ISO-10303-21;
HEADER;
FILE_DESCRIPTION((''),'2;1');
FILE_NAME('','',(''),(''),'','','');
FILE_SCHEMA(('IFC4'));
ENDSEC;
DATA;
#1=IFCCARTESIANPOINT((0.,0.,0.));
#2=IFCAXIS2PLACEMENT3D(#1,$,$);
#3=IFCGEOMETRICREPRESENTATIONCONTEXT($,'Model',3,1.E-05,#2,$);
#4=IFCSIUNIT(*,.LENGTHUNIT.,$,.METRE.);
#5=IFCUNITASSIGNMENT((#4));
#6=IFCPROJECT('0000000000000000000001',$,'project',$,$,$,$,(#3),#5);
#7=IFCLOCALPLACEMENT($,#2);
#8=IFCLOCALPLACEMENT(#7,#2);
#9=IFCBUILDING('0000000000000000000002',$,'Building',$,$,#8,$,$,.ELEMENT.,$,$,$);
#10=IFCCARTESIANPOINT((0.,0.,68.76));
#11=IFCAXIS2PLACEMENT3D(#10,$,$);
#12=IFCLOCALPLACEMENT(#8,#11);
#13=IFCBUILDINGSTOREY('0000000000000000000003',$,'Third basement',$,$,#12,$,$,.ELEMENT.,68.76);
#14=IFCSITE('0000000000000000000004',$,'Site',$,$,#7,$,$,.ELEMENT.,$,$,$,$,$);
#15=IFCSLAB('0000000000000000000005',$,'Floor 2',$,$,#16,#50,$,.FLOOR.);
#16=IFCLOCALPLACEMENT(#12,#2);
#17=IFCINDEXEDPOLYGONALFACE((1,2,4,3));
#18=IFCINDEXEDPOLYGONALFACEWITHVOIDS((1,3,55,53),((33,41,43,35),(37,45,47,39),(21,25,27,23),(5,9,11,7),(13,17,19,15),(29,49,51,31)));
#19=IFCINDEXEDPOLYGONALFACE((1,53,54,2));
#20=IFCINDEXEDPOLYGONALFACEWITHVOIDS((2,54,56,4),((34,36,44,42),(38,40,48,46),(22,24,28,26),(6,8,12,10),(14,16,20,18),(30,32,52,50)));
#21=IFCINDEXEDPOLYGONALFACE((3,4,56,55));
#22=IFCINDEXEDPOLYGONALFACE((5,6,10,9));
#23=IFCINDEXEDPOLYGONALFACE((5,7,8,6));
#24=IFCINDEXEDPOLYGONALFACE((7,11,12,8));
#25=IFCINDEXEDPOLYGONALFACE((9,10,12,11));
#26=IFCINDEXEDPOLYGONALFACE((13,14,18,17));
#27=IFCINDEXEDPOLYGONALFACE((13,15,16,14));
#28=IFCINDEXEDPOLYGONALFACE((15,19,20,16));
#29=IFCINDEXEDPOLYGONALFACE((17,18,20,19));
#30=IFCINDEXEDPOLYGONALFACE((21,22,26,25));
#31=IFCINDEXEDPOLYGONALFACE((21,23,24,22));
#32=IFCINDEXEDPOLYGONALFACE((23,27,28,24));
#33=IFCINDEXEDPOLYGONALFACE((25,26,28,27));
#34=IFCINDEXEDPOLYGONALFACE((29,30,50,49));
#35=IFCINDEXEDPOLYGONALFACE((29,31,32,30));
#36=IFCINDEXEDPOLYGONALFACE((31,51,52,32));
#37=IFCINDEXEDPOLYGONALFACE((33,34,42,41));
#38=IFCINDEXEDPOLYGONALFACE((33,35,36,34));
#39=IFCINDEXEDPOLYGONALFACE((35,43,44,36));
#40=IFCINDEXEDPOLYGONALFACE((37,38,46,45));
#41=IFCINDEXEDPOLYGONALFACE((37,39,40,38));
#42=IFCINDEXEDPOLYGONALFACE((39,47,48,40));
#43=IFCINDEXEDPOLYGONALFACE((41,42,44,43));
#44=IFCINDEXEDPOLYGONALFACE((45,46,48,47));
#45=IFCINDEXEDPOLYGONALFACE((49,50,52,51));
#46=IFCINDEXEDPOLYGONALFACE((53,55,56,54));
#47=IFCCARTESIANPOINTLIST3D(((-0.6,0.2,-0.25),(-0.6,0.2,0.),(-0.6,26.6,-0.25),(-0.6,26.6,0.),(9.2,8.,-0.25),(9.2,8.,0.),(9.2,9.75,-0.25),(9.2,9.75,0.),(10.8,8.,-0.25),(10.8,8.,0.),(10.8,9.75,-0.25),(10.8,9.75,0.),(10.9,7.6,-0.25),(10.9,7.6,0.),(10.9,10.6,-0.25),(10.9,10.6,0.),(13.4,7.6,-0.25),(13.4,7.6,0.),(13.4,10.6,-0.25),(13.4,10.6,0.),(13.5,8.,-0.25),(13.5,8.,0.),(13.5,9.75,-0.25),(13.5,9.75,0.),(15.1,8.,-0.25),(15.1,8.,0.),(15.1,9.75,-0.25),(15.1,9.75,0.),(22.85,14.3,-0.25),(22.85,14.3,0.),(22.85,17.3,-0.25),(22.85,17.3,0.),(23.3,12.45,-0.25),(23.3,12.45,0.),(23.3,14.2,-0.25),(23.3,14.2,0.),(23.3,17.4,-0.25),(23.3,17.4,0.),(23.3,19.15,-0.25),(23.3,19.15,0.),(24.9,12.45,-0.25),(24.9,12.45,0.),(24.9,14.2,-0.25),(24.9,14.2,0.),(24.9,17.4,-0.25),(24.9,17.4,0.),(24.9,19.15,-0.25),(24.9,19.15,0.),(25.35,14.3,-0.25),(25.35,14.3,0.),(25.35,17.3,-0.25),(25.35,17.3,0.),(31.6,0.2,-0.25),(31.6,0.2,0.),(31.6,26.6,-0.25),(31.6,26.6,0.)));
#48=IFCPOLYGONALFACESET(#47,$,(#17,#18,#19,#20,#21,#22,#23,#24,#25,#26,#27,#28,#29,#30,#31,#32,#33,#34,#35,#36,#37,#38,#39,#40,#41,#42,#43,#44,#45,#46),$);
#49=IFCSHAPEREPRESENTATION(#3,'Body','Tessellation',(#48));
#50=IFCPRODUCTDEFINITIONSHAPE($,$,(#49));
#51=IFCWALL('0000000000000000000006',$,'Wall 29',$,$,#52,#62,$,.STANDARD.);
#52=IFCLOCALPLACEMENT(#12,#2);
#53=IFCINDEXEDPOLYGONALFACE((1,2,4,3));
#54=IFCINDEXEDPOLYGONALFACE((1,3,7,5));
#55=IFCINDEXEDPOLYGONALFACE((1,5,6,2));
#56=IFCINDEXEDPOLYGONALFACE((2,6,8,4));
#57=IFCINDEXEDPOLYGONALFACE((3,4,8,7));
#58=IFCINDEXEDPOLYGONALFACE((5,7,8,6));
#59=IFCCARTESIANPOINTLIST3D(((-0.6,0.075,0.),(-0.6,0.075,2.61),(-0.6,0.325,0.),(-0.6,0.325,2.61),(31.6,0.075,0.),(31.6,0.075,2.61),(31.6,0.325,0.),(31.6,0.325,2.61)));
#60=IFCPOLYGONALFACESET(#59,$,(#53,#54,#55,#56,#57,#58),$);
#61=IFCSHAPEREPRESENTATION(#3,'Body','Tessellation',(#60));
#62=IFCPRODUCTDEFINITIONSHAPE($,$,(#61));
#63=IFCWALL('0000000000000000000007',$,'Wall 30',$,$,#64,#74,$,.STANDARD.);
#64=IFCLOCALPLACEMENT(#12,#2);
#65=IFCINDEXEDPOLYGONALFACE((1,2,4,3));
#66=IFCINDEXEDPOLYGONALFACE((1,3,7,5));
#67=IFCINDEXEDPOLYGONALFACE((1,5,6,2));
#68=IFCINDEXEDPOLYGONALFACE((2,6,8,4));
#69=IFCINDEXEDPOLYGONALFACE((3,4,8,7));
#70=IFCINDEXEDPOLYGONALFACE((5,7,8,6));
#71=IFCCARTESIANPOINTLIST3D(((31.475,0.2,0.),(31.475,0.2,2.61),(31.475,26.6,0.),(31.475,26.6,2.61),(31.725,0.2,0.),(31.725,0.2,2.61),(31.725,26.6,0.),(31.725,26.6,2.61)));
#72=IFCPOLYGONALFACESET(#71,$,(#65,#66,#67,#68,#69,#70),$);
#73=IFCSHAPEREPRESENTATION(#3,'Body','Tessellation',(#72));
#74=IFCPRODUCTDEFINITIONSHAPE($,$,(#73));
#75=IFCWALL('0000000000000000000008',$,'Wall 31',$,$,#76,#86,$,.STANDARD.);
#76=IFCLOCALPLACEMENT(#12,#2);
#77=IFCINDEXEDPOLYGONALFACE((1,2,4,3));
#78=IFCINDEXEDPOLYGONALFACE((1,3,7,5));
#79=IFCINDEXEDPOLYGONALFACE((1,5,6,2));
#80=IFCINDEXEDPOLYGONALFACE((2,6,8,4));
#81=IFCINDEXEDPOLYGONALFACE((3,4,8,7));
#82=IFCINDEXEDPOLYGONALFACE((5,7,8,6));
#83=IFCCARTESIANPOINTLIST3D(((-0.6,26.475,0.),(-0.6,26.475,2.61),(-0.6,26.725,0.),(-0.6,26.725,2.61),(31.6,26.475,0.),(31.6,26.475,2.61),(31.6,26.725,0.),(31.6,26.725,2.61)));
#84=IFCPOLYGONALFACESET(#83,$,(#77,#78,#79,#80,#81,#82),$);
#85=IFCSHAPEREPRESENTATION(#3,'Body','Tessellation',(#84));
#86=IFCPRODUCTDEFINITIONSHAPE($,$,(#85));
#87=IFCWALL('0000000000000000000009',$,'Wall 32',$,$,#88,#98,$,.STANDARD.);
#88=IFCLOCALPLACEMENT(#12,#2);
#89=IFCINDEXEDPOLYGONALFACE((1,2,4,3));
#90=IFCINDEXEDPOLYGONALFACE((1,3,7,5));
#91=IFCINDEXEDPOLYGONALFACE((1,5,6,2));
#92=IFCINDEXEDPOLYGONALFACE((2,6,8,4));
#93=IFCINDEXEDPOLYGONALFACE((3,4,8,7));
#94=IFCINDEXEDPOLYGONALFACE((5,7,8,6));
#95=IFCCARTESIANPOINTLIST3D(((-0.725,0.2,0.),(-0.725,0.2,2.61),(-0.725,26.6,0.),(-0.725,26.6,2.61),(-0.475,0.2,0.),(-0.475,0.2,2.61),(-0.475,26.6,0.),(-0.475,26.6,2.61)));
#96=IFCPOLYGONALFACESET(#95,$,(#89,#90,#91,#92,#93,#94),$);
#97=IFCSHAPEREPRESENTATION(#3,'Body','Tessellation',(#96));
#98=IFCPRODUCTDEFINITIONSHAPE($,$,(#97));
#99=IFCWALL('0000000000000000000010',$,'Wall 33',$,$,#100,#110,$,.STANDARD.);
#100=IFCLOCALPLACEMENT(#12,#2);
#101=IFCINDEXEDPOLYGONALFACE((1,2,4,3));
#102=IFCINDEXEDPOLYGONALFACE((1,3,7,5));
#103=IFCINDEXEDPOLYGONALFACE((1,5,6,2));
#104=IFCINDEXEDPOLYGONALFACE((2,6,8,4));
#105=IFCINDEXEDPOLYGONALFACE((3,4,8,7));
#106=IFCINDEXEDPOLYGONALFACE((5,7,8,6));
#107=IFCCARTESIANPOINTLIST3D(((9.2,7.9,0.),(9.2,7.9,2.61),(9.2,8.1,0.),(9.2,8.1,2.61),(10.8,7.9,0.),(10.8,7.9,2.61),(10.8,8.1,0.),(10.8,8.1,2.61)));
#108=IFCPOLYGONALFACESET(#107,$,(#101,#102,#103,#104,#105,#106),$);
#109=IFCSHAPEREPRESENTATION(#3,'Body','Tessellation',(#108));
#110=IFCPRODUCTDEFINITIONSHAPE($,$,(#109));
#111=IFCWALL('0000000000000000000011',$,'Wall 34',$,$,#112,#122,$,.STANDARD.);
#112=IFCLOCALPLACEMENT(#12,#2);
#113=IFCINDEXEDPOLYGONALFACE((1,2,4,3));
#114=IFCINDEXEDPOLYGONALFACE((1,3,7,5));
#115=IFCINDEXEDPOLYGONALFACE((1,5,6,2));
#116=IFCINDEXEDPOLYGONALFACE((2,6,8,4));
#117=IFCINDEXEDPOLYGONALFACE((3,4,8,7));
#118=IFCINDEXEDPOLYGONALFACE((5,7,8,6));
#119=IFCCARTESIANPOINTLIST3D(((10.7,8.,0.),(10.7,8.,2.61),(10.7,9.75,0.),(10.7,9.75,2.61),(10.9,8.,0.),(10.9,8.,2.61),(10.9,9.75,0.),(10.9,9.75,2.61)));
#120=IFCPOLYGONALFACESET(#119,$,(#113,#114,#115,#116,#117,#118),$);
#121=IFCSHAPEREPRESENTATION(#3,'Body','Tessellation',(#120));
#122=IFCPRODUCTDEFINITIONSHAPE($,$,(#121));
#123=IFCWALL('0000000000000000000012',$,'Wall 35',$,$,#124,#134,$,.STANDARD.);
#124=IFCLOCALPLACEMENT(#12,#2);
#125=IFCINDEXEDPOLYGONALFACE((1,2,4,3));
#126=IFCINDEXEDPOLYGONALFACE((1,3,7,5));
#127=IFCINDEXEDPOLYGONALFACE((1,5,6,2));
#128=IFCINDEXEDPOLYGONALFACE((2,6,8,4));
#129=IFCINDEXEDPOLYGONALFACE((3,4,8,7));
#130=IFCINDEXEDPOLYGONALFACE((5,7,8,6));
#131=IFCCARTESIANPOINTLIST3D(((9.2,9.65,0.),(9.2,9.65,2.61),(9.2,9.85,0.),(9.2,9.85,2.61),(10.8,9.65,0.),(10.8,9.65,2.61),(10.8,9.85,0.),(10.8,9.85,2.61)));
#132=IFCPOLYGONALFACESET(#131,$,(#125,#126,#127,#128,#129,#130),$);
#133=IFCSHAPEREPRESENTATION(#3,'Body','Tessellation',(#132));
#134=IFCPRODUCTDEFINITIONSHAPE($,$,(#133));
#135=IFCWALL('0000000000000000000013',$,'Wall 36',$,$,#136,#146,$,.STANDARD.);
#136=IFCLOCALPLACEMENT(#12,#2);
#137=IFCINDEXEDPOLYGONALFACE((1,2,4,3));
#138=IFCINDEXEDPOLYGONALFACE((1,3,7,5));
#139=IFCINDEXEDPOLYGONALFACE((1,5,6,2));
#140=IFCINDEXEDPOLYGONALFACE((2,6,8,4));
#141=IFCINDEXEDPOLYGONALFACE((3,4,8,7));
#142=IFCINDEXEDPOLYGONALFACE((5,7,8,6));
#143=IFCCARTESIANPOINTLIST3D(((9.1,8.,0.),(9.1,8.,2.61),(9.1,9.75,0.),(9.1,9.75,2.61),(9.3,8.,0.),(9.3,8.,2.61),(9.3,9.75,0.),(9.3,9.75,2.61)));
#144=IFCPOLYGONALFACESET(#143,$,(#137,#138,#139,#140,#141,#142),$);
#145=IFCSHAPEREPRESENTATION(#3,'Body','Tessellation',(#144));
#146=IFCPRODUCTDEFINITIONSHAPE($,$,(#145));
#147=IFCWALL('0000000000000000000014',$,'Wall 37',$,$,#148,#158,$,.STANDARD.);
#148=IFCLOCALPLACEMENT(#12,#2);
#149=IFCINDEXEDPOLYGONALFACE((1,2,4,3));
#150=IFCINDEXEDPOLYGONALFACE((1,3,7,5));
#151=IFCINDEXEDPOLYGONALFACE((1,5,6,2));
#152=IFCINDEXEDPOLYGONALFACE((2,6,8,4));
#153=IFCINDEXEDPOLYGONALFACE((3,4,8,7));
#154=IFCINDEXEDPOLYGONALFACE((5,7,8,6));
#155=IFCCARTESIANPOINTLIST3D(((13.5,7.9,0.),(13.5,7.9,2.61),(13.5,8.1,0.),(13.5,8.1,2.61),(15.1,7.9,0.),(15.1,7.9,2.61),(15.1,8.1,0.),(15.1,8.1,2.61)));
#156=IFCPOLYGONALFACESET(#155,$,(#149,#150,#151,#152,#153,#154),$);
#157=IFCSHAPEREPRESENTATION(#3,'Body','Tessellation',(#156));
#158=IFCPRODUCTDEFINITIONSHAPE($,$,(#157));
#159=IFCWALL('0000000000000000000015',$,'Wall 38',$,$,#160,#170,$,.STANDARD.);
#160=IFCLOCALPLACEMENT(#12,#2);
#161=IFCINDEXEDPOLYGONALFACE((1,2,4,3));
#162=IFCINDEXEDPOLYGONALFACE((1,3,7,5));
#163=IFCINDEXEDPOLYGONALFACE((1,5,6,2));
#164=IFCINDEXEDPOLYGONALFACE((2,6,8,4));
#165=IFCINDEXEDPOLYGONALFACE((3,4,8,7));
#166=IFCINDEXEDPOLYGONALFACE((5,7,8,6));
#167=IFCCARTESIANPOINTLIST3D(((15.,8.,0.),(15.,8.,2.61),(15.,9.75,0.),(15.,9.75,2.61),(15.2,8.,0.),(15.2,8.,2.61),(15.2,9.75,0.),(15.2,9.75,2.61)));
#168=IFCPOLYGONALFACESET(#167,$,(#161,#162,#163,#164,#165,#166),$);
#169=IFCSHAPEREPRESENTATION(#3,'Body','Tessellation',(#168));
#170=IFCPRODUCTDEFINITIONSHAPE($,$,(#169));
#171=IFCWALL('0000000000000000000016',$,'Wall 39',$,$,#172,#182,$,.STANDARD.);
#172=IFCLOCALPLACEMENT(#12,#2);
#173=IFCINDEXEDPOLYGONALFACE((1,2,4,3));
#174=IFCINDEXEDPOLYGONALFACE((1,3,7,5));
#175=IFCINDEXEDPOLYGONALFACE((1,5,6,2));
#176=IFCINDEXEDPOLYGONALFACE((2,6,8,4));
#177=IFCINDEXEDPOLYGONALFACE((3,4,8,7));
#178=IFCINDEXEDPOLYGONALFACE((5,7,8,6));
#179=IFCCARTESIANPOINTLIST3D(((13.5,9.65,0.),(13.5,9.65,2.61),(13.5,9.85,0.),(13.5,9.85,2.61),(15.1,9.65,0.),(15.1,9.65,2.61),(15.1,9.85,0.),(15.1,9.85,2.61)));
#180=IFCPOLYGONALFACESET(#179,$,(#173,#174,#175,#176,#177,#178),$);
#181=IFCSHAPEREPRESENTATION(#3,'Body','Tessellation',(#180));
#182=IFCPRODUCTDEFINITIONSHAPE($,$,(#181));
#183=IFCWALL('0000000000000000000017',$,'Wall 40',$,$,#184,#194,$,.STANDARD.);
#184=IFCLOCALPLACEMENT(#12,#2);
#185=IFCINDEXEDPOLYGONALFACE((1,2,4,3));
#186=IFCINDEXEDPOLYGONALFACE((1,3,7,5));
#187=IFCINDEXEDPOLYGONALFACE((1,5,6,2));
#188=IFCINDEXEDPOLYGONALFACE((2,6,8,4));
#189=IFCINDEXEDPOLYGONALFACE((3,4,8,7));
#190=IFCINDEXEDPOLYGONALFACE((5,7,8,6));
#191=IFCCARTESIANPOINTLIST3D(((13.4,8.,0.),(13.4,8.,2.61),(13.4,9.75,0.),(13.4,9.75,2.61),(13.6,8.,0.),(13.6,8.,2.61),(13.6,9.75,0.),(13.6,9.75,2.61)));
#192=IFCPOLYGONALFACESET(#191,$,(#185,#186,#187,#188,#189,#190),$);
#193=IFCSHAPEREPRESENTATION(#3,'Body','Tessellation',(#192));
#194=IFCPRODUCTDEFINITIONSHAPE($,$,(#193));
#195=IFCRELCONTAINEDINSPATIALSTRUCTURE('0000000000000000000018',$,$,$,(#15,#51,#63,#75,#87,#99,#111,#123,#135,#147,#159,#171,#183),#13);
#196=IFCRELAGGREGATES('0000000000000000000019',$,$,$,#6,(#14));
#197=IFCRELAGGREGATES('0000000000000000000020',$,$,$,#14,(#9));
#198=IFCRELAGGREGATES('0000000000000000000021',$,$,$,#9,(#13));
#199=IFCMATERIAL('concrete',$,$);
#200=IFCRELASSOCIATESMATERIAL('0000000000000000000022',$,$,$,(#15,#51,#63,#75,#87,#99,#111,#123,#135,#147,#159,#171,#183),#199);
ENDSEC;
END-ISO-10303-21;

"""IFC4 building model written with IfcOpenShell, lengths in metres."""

from ifc_helpers import new_model, si_unit, frame, frame_2d, origin, place, context, project, spatial, polyline, rectangle, outline, extrude, material, element, save


model = new_model("IFC4")

# Units and contexts
model_context = context("Model", 3, precision=1e-05, world=origin())
ifc_project = project(units=[si_unit("LENGTHUNIT", "METRE")], contexts=[model_context])

# Site, building, storey
site_placement = place(None, origin())
site = spatial("IfcSite", under=ifc_project, at=site_placement, Name="Site", CompositionType="ELEMENT")
building_placement = place(site_placement, origin())
building = spatial("IfcBuilding", under=site, at=building_placement, Name="Building", CompositionType="ELEMENT")
storey_placement = place(building_placement, frame((0.0, 0.0, 68.76)))
storey = spatial("IfcBuildingStorey", under=building, at=storey_placement, Name="Third basement", CompositionType="ELEMENT", Elevation=68.76)

# Slab
ifc_material = material(Name="concrete")
slab_placement = place(storey_placement, frame((0.0, 0.0, -0.25), z_axis=(0.0, 0.0, 1.0), x_axis=(1.0, 0.0, 0.0)))
element("IfcSlab", 1, at=slab_placement, inside=storey, material=ifc_material, Name="Floor 2", PredefinedType="FLOOR", context=model_context, shape_type="SweptSolid", body=[
    extrude(outline(polyline([(-0.6, 0.2), (31.6, 0.2), (31.6, 26.6), (-0.6, 26.6), (-0.6, 0.2)]), holes=[polyline([(10.9, 7.6), (13.4, 7.6), (13.4, 10.6), (10.9, 10.6), (10.9, 7.6)]), polyline([(9.2, 8.0), (10.8, 8.0), (10.8, 9.75), (9.2, 9.75), (9.2, 8.0)]), polyline([(13.5, 8.0), (15.1, 8.0), (15.1, 9.75), (13.5, 9.75), (13.5, 8.0)]), polyline([(22.85, 14.3), (25.35, 14.3), (25.35, 17.3), (22.85, 17.3), (22.85, 14.3)]), polyline([(23.3, 17.4), (24.9, 17.4), (24.9, 19.15), (23.3, 19.15), (23.3, 17.4)]), polyline([(23.3, 12.45), (24.9, 12.45), (24.9, 14.2), (23.3, 14.2), (23.3, 12.45)])]), origin(), (0.0, 0.0, 1.0), 0.25),
])

# Walls
wall_1_placement = place(storey_placement, frame((-0.6, 0.2, 0.0), z_axis=(0.0, 0.0, 1.0), x_axis=(1.0, 0.0, 0.0)))
element("IfcWall", 2, at=wall_1_placement, inside=storey, material=ifc_material, Name="Wall 29", PredefinedType="STANDARD", context=model_context, shape_type="SweptSolid", body=[
    extrude(rectangle(XDim=32.2, YDim=0.25, at=frame_2d((16.1, 0.0))), origin(), (0.0, 0.0, 1.0), 2.61),
])
wall_2_placement = place(storey_placement, frame((31.6, 0.2, 0.0), z_axis=(0.0, 0.0, 1.0), x_axis=(0.0, 1.0, 0.0)))
element("IfcWall", 3, at=wall_2_placement, inside=storey, material=ifc_material, Name="Wall 30", PredefinedType="STANDARD", context=model_context, shape_type="SweptSolid", body=[
    extrude(rectangle(XDim=26.4, YDim=0.25, at=frame_2d((13.2, 0.0))), origin(), (0.0, 0.0, 1.0), 2.61),
])
wall_3_placement = place(storey_placement, frame((31.6, 26.6, 0.0), z_axis=(0.0, 0.0, 1.0), x_axis=(-1.0, 0.0, 0.0)))
element("IfcWall", 4, at=wall_3_placement, inside=storey, material=ifc_material, Name="Wall 31", PredefinedType="STANDARD", context=model_context, shape_type="SweptSolid", body=[
    extrude(rectangle(XDim=32.2, YDim=0.25, at=frame_2d((16.1, 0.0))), origin(), (0.0, 0.0, 1.0), 2.61),
])
wall_4_placement = place(storey_placement, frame((-0.6, 26.6, 0.0), z_axis=(0.0, 0.0, 1.0), x_axis=(0.0, -1.0, 0.0)))
element("IfcWall", 5, at=wall_4_placement, inside=storey, material=ifc_material, Name="Wall 32", PredefinedType="STANDARD", context=model_context, shape_type="SweptSolid", body=[
    extrude(rectangle(XDim=26.4, YDim=0.25, at=frame_2d((13.2, 0.0))), origin(), (0.0, 0.0, 1.0), 2.61),
])
wall_5_placement = place(storey_placement, frame((9.2, 8.0, 0.0), z_axis=(0.0, 0.0, 1.0), x_axis=(1.0, 0.0, 0.0)))
element("IfcWall", 6, at=wall_5_placement, inside=storey, material=ifc_material, Name="Wall 33", PredefinedType="STANDARD", context=model_context, shape_type="SweptSolid", body=[
    extrude(rectangle(XDim=1.6, YDim=0.2, at=frame_2d((0.8, 0.0))), origin(), (0.0, 0.0, 1.0), 2.61),
])
wall_6_placement = place(storey_placement, frame((10.8, 8.0, 0.0), z_axis=(0.0, 0.0, 1.0), x_axis=(0.0, 1.0, 0.0)))
element("IfcWall", 7, at=wall_6_placement, inside=storey, material=ifc_material, Name="Wall 34", PredefinedType="STANDARD", context=model_context, shape_type="SweptSolid", body=[
    extrude(rectangle(XDim=1.75, YDim=0.2, at=frame_2d((0.875, 0.0))), origin(), (0.0, 0.0, 1.0), 2.61),
])
wall_7_placement = place(storey_placement, frame((10.8, 9.75, 0.0), z_axis=(0.0, 0.0, 1.0), x_axis=(-1.0, 0.0, 0.0)))
element("IfcWall", 8, at=wall_7_placement, inside=storey, material=ifc_material, Name="Wall 35", PredefinedType="STANDARD", context=model_context, shape_type="SweptSolid", body=[
    extrude(rectangle(XDim=1.6, YDim=0.2, at=frame_2d((0.8, 0.0))), origin(), (0.0, 0.0, 1.0), 2.61),
])
wall_8_placement = place(storey_placement, frame((9.2, 9.75, 0.0), z_axis=(0.0, 0.0, 1.0), x_axis=(0.0, -1.0, 0.0)))
element("IfcWall", 9, at=wall_8_placement, inside=storey, material=ifc_material, Name="Wall 36", PredefinedType="STANDARD", context=model_context, shape_type="SweptSolid", body=[
    extrude(rectangle(XDim=1.75, YDim=0.2, at=frame_2d((0.875, 0.0))), origin(), (0.0, 0.0, 1.0), 2.61),
])
wall_9_placement = place(storey_placement, frame((13.5, 8.0, 0.0), z_axis=(0.0, 0.0, 1.0), x_axis=(1.0, 0.0, 0.0)))
element("IfcWall", 10, at=wall_9_placement, inside=storey, material=ifc_material, Name="Wall 37", PredefinedType="STANDARD", context=model_context, shape_type="SweptSolid", body=[
    extrude(rectangle(XDim=1.6, YDim=0.2, at=frame_2d((0.8, 0.0))), origin(), (0.0, 0.0, 1.0), 2.61),
])
wall_10_placement = place(storey_placement, frame((15.1, 8.0, 0.0), z_axis=(0.0, 0.0, 1.0), x_axis=(0.0, 1.0, 0.0)))
element("IfcWall", 11, at=wall_10_placement, inside=storey, material=ifc_material, Name="Wall 38", PredefinedType="STANDARD", context=model_context, shape_type="SweptSolid", body=[
    extrude(rectangle(XDim=1.75, YDim=0.2, at=frame_2d((0.875, 0.0))), origin(), (0.0, 0.0, 1.0), 2.61),
])
wall_11_placement = place(storey_placement, frame((15.1, 9.75, 0.0), z_axis=(0.0, 0.0, 1.0), x_axis=(-1.0, 0.0, 0.0)))
element("IfcWall", 12, at=wall_11_placement, inside=storey, material=ifc_material, Name="Wall 39", PredefinedType="STANDARD", context=model_context, shape_type="SweptSolid", body=[
    extrude(rectangle(XDim=1.6, YDim=0.2, at=frame_2d((0.8, 0.0))), origin(), (0.0, 0.0, 1.0), 2.61),
])
wall_12_placement = place(storey_placement, frame((13.5, 9.75, 0.0), z_axis=(0.0, 0.0, 1.0), x_axis=(0.0, -1.0, 0.0)))
element("IfcWall", 13, at=wall_12_placement, inside=storey, material=ifc_material, Name="Wall 40", PredefinedType="STANDARD", context=model_context, shape_type="SweptSolid", body=[
    extrude(rectangle(XDim=1.75, YDim=0.2, at=frame_2d((0.875, 0.0))), origin(), (0.0, 0.0, 1.0), 2.61),
])

save(model, "model.ifc")
